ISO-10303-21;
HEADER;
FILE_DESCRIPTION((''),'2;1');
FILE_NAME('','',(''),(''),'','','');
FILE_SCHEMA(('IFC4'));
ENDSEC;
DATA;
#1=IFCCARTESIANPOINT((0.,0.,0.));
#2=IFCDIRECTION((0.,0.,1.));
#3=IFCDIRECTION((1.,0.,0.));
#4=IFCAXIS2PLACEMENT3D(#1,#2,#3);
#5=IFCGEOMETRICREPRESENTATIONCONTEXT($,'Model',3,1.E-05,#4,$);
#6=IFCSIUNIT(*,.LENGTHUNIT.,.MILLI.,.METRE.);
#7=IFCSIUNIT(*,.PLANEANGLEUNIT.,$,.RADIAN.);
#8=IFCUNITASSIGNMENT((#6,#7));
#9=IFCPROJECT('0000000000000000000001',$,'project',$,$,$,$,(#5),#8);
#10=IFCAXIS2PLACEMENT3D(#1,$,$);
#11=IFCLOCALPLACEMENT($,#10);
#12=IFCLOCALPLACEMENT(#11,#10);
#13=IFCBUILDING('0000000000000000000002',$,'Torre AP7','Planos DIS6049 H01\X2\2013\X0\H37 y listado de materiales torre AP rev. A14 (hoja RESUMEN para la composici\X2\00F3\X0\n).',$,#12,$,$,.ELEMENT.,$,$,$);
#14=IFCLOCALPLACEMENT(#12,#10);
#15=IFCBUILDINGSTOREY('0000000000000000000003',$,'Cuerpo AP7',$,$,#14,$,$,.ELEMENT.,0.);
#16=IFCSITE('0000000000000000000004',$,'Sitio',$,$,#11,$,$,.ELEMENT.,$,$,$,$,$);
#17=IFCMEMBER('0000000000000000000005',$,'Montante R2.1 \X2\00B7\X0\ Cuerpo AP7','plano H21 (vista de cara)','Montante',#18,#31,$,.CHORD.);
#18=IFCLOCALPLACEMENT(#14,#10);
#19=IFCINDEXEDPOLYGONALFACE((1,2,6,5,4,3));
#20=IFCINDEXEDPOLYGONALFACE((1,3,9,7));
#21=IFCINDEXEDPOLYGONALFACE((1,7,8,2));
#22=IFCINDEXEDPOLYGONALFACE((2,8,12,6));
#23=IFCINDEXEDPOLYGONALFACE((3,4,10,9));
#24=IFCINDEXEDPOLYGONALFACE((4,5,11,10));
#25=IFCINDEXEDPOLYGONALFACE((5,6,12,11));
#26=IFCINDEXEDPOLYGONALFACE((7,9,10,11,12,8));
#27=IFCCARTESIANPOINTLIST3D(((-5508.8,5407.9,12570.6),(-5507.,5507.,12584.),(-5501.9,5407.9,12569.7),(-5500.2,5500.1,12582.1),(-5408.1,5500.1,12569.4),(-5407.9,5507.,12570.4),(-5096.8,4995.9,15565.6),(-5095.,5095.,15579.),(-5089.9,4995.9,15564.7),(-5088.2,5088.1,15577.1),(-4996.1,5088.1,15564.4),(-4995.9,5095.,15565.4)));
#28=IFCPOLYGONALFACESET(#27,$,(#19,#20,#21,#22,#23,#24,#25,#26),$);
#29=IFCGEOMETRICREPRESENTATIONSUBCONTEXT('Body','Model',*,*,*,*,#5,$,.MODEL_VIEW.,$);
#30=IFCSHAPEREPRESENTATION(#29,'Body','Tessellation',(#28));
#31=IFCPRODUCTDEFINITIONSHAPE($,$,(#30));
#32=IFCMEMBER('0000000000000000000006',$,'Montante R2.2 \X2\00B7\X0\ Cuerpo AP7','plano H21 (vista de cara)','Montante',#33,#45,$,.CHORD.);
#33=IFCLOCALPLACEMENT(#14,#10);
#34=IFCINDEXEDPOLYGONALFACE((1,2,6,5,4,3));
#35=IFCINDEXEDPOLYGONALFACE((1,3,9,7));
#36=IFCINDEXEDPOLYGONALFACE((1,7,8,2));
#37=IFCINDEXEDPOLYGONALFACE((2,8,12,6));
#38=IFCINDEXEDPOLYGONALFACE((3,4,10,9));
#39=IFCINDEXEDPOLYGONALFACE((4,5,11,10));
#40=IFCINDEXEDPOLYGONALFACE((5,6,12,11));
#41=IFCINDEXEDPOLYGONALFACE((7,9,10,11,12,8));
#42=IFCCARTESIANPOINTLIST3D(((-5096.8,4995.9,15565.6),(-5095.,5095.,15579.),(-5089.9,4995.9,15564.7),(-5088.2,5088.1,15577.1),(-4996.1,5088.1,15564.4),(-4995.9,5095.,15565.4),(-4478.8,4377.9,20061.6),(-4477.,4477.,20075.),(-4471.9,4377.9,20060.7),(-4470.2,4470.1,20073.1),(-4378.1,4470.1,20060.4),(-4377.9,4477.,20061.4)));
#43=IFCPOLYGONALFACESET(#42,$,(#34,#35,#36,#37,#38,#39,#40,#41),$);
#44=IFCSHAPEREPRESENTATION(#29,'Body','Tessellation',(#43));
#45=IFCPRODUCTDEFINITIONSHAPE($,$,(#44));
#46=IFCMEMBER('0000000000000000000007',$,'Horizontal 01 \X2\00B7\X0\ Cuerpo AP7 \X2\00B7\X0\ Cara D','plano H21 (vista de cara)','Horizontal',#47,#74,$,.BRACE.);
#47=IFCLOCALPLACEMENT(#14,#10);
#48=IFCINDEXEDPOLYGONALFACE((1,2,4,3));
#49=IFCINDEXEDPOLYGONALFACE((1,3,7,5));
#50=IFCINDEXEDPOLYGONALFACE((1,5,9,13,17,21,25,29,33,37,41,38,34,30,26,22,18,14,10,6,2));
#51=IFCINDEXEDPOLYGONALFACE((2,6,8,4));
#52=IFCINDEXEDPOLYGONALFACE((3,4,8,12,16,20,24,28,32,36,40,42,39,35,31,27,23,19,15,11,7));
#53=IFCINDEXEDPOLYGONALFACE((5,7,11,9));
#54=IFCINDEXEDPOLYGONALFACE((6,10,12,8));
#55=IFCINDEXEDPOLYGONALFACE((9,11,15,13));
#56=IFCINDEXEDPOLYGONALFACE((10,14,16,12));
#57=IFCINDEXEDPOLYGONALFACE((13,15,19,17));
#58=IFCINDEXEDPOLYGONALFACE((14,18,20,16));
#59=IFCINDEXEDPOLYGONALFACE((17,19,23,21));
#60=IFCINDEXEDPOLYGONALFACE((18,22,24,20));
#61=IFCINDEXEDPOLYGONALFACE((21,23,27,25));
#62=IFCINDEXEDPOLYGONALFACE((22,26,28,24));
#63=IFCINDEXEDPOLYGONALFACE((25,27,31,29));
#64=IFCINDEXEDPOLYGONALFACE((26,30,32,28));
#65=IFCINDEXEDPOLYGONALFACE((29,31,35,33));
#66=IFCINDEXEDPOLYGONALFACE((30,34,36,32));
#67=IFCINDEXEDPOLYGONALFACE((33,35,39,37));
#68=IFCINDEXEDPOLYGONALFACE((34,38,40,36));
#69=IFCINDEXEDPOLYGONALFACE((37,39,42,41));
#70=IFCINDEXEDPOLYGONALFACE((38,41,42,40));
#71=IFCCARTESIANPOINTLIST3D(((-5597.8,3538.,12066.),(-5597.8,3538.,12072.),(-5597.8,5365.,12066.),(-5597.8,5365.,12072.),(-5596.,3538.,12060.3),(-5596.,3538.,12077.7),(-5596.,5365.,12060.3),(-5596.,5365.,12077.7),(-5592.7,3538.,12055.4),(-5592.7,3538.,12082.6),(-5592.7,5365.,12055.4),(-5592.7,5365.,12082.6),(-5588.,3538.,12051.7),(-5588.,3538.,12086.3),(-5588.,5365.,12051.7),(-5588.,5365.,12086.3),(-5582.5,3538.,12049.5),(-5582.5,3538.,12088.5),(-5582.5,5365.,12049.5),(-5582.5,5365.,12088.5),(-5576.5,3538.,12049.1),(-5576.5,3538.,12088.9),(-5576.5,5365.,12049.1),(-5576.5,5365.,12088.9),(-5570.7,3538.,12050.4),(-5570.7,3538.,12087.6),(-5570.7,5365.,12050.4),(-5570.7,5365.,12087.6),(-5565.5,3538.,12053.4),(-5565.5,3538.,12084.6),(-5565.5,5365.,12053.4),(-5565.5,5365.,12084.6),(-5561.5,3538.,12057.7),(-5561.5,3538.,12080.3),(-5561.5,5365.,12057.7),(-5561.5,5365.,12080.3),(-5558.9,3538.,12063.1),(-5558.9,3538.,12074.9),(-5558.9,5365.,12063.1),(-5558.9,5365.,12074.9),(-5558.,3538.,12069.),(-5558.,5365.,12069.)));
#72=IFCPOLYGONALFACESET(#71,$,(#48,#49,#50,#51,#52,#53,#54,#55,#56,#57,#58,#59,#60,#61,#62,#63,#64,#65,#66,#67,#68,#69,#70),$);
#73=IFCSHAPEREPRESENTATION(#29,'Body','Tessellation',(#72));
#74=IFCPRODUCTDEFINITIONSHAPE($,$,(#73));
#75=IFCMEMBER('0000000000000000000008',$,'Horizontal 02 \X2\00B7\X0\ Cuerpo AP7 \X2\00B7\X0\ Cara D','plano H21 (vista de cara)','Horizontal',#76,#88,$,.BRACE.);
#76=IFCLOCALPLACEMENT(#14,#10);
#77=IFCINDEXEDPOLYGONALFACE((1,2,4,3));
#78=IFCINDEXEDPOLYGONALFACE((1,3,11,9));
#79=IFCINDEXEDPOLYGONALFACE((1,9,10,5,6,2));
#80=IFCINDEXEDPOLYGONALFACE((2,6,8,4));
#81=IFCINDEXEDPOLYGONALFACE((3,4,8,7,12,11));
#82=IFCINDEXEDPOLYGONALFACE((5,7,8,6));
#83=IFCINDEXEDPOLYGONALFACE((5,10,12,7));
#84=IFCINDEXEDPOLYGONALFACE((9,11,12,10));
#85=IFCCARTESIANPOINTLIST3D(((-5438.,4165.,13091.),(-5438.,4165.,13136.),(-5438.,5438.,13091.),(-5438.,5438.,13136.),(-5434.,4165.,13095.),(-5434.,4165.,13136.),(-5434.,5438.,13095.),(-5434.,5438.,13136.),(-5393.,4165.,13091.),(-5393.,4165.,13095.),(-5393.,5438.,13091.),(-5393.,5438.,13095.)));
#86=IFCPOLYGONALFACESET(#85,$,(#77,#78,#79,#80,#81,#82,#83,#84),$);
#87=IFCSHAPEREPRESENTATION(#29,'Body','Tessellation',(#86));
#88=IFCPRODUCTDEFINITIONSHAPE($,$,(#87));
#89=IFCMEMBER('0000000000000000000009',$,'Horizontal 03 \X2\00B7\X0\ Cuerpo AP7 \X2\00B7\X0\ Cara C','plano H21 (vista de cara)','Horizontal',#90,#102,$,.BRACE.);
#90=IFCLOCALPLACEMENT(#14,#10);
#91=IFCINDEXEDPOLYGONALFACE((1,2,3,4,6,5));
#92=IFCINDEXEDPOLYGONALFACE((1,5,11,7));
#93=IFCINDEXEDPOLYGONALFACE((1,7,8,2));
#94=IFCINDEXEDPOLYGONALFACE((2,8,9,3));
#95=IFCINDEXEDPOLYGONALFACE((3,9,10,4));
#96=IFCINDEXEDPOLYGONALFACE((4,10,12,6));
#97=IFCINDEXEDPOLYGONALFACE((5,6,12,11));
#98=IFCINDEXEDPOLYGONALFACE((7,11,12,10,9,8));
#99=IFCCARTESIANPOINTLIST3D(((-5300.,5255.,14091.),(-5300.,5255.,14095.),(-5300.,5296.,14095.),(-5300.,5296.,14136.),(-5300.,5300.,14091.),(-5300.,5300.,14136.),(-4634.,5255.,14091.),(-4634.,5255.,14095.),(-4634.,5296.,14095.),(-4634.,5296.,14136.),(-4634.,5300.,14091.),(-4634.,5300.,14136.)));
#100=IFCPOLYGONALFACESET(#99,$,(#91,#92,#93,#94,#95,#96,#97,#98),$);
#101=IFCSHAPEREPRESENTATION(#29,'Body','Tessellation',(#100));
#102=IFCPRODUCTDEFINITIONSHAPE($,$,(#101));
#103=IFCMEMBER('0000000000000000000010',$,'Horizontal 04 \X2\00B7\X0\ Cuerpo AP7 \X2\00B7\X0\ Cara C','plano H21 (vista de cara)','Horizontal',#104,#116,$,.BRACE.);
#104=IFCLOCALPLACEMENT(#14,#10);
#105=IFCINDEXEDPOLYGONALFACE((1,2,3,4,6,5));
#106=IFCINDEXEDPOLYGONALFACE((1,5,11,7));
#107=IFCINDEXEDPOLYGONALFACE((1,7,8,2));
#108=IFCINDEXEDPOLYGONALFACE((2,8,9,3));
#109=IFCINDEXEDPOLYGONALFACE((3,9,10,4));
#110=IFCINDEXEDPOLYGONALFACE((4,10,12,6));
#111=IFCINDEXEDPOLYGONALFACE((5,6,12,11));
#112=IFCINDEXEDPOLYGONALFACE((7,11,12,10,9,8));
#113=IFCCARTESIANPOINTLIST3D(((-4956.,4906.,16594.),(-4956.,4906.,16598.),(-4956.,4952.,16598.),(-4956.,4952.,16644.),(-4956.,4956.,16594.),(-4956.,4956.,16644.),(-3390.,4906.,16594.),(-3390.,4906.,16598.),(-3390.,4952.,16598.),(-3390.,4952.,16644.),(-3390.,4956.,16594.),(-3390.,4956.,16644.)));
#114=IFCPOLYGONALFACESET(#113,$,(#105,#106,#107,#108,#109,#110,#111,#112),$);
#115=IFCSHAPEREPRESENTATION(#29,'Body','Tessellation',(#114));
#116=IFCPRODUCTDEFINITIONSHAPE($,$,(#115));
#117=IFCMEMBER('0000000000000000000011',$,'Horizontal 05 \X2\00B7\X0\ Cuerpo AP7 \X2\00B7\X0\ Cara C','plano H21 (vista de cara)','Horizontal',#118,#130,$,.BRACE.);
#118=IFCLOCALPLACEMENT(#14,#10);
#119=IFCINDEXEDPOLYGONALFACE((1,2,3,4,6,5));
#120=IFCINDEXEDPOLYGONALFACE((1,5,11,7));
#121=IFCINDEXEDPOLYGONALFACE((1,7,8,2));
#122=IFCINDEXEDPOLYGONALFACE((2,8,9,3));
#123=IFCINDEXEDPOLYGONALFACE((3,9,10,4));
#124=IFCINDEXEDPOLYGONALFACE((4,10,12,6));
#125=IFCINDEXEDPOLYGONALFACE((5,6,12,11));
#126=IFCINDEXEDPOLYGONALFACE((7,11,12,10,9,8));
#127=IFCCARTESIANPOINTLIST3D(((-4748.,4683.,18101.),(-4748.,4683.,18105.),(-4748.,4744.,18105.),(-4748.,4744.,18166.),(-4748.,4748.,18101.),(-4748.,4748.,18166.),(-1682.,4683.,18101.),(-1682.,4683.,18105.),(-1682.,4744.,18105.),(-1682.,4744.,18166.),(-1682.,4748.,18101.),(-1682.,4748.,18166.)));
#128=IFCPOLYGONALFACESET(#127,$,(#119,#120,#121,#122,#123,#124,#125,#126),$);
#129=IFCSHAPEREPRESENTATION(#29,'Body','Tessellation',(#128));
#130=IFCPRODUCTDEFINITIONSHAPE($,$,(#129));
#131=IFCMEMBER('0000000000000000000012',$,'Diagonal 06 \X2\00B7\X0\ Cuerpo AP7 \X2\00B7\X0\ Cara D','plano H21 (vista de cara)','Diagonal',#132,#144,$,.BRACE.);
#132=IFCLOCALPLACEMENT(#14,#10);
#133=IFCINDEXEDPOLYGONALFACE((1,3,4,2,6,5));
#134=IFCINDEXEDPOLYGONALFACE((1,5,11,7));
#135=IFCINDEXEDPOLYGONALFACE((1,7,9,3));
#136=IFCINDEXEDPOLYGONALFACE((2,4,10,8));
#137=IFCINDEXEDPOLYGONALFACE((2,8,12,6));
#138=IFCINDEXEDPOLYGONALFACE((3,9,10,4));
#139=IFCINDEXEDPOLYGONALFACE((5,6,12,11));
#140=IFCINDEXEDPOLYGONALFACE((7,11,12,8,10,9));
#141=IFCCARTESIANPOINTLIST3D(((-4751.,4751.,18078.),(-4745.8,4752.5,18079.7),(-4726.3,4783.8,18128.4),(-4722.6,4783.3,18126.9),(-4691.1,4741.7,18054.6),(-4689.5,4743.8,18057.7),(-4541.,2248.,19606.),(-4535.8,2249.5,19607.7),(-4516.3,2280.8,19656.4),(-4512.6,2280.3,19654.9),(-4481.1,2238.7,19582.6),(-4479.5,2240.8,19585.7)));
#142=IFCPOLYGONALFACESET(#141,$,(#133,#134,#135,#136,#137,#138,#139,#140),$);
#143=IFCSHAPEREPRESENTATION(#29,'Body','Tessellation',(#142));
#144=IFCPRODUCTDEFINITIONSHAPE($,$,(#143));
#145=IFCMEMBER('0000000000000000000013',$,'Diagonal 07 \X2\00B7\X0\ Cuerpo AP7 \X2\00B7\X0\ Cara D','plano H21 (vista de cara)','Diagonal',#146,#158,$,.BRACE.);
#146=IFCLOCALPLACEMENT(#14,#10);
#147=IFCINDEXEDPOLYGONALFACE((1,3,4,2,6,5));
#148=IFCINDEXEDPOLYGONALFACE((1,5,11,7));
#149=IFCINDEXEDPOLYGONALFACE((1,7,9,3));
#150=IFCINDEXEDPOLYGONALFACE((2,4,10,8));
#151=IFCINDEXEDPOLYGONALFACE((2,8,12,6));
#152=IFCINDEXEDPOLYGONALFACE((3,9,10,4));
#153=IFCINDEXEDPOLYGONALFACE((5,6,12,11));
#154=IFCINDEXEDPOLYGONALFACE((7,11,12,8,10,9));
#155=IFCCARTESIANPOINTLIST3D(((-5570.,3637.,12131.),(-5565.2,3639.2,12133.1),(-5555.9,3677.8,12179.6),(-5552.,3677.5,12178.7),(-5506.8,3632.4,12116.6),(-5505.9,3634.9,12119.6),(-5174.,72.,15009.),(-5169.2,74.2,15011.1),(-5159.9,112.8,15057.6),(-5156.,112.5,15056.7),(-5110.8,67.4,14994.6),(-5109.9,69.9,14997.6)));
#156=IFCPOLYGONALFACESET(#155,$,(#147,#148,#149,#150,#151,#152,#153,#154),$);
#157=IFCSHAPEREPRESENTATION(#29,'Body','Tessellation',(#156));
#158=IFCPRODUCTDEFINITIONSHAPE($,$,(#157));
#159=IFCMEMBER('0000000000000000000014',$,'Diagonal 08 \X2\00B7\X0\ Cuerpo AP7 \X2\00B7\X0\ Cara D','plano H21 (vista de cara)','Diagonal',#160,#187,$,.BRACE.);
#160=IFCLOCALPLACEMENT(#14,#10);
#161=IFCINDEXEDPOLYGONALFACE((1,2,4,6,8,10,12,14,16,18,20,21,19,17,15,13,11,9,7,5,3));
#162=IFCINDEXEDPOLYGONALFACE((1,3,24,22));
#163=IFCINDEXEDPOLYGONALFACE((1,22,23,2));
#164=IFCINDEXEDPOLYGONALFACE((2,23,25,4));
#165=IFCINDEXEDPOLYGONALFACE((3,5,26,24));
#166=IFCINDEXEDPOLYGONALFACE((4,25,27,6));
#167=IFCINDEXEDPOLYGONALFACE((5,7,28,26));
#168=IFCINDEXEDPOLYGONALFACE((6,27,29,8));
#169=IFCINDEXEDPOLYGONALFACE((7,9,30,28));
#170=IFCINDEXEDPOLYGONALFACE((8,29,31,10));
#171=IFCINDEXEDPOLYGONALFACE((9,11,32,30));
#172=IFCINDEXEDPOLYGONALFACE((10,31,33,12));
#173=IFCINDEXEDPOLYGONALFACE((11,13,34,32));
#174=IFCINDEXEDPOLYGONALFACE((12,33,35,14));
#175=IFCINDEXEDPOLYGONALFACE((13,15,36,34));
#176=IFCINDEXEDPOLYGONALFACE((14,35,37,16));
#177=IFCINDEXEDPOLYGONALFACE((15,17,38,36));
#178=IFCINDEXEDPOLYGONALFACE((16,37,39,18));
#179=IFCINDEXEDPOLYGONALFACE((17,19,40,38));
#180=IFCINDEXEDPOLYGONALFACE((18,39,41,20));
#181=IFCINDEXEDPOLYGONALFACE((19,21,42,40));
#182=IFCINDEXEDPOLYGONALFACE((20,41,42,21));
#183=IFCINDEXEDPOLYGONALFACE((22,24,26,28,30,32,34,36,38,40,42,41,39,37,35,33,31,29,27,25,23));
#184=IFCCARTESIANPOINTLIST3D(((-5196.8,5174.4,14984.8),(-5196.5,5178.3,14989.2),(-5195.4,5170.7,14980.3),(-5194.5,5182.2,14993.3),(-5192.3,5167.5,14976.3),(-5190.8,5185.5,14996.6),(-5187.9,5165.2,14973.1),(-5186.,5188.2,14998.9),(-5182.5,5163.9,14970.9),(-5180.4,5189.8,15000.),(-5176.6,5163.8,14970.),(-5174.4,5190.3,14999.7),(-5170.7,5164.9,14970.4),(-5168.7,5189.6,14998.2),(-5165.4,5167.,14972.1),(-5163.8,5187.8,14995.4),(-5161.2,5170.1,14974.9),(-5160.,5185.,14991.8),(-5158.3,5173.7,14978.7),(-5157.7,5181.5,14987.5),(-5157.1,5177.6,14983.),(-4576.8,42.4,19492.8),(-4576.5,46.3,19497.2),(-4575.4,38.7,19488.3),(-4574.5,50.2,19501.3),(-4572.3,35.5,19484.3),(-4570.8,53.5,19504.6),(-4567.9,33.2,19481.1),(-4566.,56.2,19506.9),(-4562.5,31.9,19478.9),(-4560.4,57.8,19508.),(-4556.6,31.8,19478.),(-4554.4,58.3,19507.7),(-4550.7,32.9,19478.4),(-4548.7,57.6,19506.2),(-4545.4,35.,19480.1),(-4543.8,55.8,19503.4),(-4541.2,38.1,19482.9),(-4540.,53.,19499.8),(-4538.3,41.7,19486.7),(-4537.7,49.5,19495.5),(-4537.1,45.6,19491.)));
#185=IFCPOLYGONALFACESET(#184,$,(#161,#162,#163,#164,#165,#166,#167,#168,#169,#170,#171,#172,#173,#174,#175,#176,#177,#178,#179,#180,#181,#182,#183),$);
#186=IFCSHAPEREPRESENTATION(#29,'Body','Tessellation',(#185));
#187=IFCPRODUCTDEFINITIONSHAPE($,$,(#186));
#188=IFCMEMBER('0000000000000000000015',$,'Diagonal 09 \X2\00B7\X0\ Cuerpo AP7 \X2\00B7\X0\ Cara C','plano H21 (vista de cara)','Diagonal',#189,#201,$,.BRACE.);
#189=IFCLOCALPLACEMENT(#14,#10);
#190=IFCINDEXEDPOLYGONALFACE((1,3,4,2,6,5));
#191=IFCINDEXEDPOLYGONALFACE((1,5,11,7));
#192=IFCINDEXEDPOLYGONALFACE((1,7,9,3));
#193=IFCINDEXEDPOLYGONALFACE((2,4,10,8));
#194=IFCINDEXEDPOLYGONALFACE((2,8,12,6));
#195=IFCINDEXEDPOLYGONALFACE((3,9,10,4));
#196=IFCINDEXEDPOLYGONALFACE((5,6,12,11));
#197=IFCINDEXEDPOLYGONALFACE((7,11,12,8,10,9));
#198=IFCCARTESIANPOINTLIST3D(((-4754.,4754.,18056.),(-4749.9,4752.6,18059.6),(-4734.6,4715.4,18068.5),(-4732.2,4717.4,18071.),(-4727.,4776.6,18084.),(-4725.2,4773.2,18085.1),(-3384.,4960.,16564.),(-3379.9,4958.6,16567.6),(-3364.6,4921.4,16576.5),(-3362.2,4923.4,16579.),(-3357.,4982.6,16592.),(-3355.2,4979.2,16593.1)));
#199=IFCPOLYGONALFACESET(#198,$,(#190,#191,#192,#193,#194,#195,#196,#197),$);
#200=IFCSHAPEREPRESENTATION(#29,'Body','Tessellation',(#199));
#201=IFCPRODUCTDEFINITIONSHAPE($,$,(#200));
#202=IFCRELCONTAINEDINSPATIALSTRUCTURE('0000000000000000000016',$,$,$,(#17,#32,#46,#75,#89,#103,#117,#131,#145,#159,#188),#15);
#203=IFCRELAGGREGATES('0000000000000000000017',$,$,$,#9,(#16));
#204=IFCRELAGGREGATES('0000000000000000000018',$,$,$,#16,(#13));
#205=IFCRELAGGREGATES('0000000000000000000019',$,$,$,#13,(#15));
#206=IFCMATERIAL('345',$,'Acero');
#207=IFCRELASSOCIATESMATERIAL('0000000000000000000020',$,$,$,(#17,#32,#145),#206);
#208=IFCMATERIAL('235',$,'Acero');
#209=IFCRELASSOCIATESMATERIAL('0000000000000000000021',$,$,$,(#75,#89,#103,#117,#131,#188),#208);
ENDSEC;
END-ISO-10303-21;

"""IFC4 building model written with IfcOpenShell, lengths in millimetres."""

from ifc_helpers import new_model, si_unit, frame, frame_2d, origin, origin_with_axes, place, context, subcontext, project, spatial, circle, l_section, extrude, material, element, save


model = new_model("IFC4")

# Units and contexts
model_context = context("Model", 3, precision=1e-05, world=origin_with_axes())
body_context = subcontext(model_context, "Body", "Model", "MODEL_VIEW")
ifc_project = project(units=[si_unit("LENGTHUNIT", "METRE", prefix="MILLI"), si_unit("PLANEANGLEUNIT", "RADIAN")], contexts=[model_context])

# Site, building, storey
site_placement = place(None, origin())
site = spatial("IfcSite", under=ifc_project, at=site_placement, Name="Sitio", CompositionType="ELEMENT")
building_placement = place(site_placement, origin())
building = spatial("IfcBuilding", under=site, at=building_placement, Name="Torre AP7", Description="Planos DIS6049 H01–H37 y listado de materiales torre AP rev. A14 (hoja RESUMEN para la composición).", CompositionType="ELEMENT")
storey_placement = place(building_placement, origin())
storey = spatial("IfcBuildingStorey", under=building, at=storey_placement, Name="Cuerpo AP7", CompositionType="ELEMENT", Elevation=0.0)

# Members
ifc_material_1 = material(Name="345", Category="Acero")
member_1_placement = place(storey_placement, frame((-5507.0, 5507.0, 12584.0), z_axis=(0.135031, -0.135031, 0.981597), x_axis=(-0.018402, -0.990841, -0.133771)))
element("IfcMember", 1, at=member_1_placement, inside=storey, material=ifc_material_1, Name="Montante R2.1 · Cuerpo AP7", Description="plano H21 (vista de cara)", ObjectType="Montante", PredefinedType="CHORD", context=body_context, shape_type="SweptSolid", body=[
    extrude(l_section(Depth=100.0, Width=100.0, Thickness=7.0, at=frame_2d((50.0, 50.0))), None, (0.0, 0.0, 1.0), 3051.1),
])
member_2_placement = place(storey_placement, frame((-5095.0, 5095.0, 15579.0), z_axis=(0.13493, -0.13493, 0.981625), x_axis=(-0.018374, -0.990855, -0.133673)))
element("IfcMember", 2, at=member_2_placement, inside=storey, material=ifc_material_1, Name="Montante R2.2 · Cuerpo AP7", Description="plano H21 (vista de cara)", ObjectType="Montante", PredefinedType="CHORD", context=body_context, shape_type="SweptSolid", body=[
    extrude(l_section(Depth=100.0, Width=100.0, Thickness=7.0, at=frame_2d((50.0, 50.0))), None, (0.0, 0.0, 1.0), 4580.2),
])
member_3_placement = place(storey_placement, frame((-5578.0, 5365.0, 12069.0), z_axis=(0.0, -1.0, 0.0), x_axis=(1.0, 0.0, 0.0)))
element("IfcMember", 3, at=member_3_placement, inside=storey, Name="Horizontal 01 · Cuerpo AP7 · Cara D", Description="plano H21 (vista de cara)", ObjectType="Horizontal", PredefinedType="BRACE", context=body_context, shape_type="SweptSolid", body=[
    extrude(circle(Radius=20.0), None, (0.0, 0.0, 1.0), 1827.0),
])
ifc_material_2 = material(Name="235", Category="Acero")
member_4_placement = place(storey_placement, frame((-5438.0, 5438.0, 13091.0), z_axis=(0.0, -1.0, 0.0), x_axis=(1.0, 0.0, 0.0)))
element("IfcMember", 4, at=member_4_placement, inside=storey, material=ifc_material_2, Name="Horizontal 02 · Cuerpo AP7 · Cara D", Description="plano H21 (vista de cara)", ObjectType="Horizontal", PredefinedType="BRACE", context=body_context, shape_type="SweptSolid", body=[
    extrude(l_section(Depth=45.0, Width=45.0, Thickness=4.0, at=frame_2d((22.5, 22.5))), None, (0.0, 0.0, 1.0), 1273.0),
])
member_5_placement = place(storey_placement, frame((-4634.0, 5300.0, 14091.0), z_axis=(-1.0, 0.0, 0.0), x_axis=(0.0, -1.0, 0.0)))
element("IfcMember", 5, at=member_5_placement, inside=storey, material=ifc_material_2, Name="Horizontal 03 · Cuerpo AP7 · Cara C", Description="plano H21 (vista de cara)", ObjectType="Horizontal", PredefinedType="BRACE", context=body_context, shape_type="SweptSolid", body=[
    extrude(l_section(Depth=45.0, Width=45.0, Thickness=4.0, at=frame_2d((22.5, 22.5))), None, (0.0, 0.0, 1.0), 666.0),
])
member_6_placement = place(storey_placement, frame((-3390.0, 4956.0, 16594.0), z_axis=(-1.0, 0.0, 0.0), x_axis=(0.0, -1.0, 0.0)))
element("IfcMember", 6, at=member_6_placement, inside=storey, material=ifc_material_2, Name="Horizontal 04 · Cuerpo AP7 · Cara C", Description="plano H21 (vista de cara)", ObjectType="Horizontal", PredefinedType="BRACE", context=body_context, shape_type="SweptSolid", body=[
    extrude(l_section(Depth=50.0, Width=50.0, Thickness=4.0, at=frame_2d((25.0, 25.0))), None, (0.0, 0.0, 1.0), 1566.0),
])
member_7_placement = place(storey_placement, frame((-1682.0, 4748.0, 18101.0), z_axis=(-1.0, 0.0, 0.0), x_axis=(0.0, -1.0, 0.0)))
element("IfcMember", 7, at=member_7_placement, inside=storey, material=ifc_material_2, Name="Horizontal 05 · Cuerpo AP7 · Cara C", Description="plano H21 (vista de cara)", ObjectType="Horizontal", PredefinedType="BRACE", context=body_context, shape_type="SweptSolid", body=[
    extrude(l_section(Depth=65.0, Width=65.0, Thickness=4.0, at=frame_2d((32.5, 32.5))), None, (0.0, 0.0, 1.0), 3066.0),
])
member_8_placement = place(storey_placement, frame((-4751.0, 4751.0, 18078.0), z_axis=(0.071427, -0.851346, 0.519719), x_axis=(0.922089, -0.142318, -0.359857)))
element("IfcMember", 8, at=member_8_placement, inside=storey, material=ifc_material_2, Name="Diagonal 06 · Cuerpo AP7 · Cara D", Description="plano H21 (vista de cara)", ObjectType="Diagonal", PredefinedType="BRACE", context=body_context, shape_type="SweptSolid", body=[
    extrude(l_section(Depth=65.0, Width=65.0, Thickness=4.0, at=frame_2d((32.5, 32.5))), None, (0.0, 0.0, 1.0), 2940.0),
])
member_9_placement = place(storey_placement, frame((-5570.0, 3637.0, 12131.0), z_axis=(0.086109, -0.775203, 0.625816), x_axis=(0.972436, -0.071222, -0.222026)))
element("IfcMember", 9, at=member_9_placement, inside=storey, material=ifc_material_1, Name="Diagonal 07 · Cuerpo AP7 · Cara D", Description="plano H21 (vista de cara)", ObjectType="Diagonal", PredefinedType="BRACE", context=body_context, shape_type="SweptSolid", body=[
    extrude(l_section(Depth=65.0, Width=65.0, Thickness=4.0, at=frame_2d((32.5, 32.5))), None, (0.0, 0.0, 1.0), 4598.8),
])
member_10_placement = place(storey_placement, frame((-5177.0, 5177.0, 14985.0), z_axis=(0.090394, -0.74823, 0.657253), x_axis=(0.934326, -0.164751, -0.316057)))
element("IfcMember", 10, at=member_10_placement, inside=storey, Name="Diagonal 08 · Cuerpo AP7 · Cara D", Description="plano H21 (vista de cara)", ObjectType="Diagonal", PredefinedType="BRACE", context=body_context, shape_type="SweptSolid", body=[
    extrude(circle(Radius=20.0), None, (0.0, 0.0, 1.0), 6858.9),
])
member_11_placement = place(storey_placement, frame((-3384.0, 4960.0, 16564.0), z_axis=(-0.67288, -0.101178, 0.7328), x_axis=(0.431654, -0.858174, 0.27787)))
element("IfcMember", 11, at=member_11_placement, inside=storey, material=ifc_material_2, Name="Diagonal 09 · Cuerpo AP7 · Cara C", Description="plano H21 (vista de cara)", ObjectType="Diagonal", PredefinedType="BRACE", context=body_context, shape_type="SweptSolid", body=[
    extrude(l_section(Depth=45.0, Width=45.0, Thickness=4.0, at=frame_2d((22.5, 22.5))), None, (0.0, 0.0, 1.0), 2036.0),
])

save(model, "model.ifc")
